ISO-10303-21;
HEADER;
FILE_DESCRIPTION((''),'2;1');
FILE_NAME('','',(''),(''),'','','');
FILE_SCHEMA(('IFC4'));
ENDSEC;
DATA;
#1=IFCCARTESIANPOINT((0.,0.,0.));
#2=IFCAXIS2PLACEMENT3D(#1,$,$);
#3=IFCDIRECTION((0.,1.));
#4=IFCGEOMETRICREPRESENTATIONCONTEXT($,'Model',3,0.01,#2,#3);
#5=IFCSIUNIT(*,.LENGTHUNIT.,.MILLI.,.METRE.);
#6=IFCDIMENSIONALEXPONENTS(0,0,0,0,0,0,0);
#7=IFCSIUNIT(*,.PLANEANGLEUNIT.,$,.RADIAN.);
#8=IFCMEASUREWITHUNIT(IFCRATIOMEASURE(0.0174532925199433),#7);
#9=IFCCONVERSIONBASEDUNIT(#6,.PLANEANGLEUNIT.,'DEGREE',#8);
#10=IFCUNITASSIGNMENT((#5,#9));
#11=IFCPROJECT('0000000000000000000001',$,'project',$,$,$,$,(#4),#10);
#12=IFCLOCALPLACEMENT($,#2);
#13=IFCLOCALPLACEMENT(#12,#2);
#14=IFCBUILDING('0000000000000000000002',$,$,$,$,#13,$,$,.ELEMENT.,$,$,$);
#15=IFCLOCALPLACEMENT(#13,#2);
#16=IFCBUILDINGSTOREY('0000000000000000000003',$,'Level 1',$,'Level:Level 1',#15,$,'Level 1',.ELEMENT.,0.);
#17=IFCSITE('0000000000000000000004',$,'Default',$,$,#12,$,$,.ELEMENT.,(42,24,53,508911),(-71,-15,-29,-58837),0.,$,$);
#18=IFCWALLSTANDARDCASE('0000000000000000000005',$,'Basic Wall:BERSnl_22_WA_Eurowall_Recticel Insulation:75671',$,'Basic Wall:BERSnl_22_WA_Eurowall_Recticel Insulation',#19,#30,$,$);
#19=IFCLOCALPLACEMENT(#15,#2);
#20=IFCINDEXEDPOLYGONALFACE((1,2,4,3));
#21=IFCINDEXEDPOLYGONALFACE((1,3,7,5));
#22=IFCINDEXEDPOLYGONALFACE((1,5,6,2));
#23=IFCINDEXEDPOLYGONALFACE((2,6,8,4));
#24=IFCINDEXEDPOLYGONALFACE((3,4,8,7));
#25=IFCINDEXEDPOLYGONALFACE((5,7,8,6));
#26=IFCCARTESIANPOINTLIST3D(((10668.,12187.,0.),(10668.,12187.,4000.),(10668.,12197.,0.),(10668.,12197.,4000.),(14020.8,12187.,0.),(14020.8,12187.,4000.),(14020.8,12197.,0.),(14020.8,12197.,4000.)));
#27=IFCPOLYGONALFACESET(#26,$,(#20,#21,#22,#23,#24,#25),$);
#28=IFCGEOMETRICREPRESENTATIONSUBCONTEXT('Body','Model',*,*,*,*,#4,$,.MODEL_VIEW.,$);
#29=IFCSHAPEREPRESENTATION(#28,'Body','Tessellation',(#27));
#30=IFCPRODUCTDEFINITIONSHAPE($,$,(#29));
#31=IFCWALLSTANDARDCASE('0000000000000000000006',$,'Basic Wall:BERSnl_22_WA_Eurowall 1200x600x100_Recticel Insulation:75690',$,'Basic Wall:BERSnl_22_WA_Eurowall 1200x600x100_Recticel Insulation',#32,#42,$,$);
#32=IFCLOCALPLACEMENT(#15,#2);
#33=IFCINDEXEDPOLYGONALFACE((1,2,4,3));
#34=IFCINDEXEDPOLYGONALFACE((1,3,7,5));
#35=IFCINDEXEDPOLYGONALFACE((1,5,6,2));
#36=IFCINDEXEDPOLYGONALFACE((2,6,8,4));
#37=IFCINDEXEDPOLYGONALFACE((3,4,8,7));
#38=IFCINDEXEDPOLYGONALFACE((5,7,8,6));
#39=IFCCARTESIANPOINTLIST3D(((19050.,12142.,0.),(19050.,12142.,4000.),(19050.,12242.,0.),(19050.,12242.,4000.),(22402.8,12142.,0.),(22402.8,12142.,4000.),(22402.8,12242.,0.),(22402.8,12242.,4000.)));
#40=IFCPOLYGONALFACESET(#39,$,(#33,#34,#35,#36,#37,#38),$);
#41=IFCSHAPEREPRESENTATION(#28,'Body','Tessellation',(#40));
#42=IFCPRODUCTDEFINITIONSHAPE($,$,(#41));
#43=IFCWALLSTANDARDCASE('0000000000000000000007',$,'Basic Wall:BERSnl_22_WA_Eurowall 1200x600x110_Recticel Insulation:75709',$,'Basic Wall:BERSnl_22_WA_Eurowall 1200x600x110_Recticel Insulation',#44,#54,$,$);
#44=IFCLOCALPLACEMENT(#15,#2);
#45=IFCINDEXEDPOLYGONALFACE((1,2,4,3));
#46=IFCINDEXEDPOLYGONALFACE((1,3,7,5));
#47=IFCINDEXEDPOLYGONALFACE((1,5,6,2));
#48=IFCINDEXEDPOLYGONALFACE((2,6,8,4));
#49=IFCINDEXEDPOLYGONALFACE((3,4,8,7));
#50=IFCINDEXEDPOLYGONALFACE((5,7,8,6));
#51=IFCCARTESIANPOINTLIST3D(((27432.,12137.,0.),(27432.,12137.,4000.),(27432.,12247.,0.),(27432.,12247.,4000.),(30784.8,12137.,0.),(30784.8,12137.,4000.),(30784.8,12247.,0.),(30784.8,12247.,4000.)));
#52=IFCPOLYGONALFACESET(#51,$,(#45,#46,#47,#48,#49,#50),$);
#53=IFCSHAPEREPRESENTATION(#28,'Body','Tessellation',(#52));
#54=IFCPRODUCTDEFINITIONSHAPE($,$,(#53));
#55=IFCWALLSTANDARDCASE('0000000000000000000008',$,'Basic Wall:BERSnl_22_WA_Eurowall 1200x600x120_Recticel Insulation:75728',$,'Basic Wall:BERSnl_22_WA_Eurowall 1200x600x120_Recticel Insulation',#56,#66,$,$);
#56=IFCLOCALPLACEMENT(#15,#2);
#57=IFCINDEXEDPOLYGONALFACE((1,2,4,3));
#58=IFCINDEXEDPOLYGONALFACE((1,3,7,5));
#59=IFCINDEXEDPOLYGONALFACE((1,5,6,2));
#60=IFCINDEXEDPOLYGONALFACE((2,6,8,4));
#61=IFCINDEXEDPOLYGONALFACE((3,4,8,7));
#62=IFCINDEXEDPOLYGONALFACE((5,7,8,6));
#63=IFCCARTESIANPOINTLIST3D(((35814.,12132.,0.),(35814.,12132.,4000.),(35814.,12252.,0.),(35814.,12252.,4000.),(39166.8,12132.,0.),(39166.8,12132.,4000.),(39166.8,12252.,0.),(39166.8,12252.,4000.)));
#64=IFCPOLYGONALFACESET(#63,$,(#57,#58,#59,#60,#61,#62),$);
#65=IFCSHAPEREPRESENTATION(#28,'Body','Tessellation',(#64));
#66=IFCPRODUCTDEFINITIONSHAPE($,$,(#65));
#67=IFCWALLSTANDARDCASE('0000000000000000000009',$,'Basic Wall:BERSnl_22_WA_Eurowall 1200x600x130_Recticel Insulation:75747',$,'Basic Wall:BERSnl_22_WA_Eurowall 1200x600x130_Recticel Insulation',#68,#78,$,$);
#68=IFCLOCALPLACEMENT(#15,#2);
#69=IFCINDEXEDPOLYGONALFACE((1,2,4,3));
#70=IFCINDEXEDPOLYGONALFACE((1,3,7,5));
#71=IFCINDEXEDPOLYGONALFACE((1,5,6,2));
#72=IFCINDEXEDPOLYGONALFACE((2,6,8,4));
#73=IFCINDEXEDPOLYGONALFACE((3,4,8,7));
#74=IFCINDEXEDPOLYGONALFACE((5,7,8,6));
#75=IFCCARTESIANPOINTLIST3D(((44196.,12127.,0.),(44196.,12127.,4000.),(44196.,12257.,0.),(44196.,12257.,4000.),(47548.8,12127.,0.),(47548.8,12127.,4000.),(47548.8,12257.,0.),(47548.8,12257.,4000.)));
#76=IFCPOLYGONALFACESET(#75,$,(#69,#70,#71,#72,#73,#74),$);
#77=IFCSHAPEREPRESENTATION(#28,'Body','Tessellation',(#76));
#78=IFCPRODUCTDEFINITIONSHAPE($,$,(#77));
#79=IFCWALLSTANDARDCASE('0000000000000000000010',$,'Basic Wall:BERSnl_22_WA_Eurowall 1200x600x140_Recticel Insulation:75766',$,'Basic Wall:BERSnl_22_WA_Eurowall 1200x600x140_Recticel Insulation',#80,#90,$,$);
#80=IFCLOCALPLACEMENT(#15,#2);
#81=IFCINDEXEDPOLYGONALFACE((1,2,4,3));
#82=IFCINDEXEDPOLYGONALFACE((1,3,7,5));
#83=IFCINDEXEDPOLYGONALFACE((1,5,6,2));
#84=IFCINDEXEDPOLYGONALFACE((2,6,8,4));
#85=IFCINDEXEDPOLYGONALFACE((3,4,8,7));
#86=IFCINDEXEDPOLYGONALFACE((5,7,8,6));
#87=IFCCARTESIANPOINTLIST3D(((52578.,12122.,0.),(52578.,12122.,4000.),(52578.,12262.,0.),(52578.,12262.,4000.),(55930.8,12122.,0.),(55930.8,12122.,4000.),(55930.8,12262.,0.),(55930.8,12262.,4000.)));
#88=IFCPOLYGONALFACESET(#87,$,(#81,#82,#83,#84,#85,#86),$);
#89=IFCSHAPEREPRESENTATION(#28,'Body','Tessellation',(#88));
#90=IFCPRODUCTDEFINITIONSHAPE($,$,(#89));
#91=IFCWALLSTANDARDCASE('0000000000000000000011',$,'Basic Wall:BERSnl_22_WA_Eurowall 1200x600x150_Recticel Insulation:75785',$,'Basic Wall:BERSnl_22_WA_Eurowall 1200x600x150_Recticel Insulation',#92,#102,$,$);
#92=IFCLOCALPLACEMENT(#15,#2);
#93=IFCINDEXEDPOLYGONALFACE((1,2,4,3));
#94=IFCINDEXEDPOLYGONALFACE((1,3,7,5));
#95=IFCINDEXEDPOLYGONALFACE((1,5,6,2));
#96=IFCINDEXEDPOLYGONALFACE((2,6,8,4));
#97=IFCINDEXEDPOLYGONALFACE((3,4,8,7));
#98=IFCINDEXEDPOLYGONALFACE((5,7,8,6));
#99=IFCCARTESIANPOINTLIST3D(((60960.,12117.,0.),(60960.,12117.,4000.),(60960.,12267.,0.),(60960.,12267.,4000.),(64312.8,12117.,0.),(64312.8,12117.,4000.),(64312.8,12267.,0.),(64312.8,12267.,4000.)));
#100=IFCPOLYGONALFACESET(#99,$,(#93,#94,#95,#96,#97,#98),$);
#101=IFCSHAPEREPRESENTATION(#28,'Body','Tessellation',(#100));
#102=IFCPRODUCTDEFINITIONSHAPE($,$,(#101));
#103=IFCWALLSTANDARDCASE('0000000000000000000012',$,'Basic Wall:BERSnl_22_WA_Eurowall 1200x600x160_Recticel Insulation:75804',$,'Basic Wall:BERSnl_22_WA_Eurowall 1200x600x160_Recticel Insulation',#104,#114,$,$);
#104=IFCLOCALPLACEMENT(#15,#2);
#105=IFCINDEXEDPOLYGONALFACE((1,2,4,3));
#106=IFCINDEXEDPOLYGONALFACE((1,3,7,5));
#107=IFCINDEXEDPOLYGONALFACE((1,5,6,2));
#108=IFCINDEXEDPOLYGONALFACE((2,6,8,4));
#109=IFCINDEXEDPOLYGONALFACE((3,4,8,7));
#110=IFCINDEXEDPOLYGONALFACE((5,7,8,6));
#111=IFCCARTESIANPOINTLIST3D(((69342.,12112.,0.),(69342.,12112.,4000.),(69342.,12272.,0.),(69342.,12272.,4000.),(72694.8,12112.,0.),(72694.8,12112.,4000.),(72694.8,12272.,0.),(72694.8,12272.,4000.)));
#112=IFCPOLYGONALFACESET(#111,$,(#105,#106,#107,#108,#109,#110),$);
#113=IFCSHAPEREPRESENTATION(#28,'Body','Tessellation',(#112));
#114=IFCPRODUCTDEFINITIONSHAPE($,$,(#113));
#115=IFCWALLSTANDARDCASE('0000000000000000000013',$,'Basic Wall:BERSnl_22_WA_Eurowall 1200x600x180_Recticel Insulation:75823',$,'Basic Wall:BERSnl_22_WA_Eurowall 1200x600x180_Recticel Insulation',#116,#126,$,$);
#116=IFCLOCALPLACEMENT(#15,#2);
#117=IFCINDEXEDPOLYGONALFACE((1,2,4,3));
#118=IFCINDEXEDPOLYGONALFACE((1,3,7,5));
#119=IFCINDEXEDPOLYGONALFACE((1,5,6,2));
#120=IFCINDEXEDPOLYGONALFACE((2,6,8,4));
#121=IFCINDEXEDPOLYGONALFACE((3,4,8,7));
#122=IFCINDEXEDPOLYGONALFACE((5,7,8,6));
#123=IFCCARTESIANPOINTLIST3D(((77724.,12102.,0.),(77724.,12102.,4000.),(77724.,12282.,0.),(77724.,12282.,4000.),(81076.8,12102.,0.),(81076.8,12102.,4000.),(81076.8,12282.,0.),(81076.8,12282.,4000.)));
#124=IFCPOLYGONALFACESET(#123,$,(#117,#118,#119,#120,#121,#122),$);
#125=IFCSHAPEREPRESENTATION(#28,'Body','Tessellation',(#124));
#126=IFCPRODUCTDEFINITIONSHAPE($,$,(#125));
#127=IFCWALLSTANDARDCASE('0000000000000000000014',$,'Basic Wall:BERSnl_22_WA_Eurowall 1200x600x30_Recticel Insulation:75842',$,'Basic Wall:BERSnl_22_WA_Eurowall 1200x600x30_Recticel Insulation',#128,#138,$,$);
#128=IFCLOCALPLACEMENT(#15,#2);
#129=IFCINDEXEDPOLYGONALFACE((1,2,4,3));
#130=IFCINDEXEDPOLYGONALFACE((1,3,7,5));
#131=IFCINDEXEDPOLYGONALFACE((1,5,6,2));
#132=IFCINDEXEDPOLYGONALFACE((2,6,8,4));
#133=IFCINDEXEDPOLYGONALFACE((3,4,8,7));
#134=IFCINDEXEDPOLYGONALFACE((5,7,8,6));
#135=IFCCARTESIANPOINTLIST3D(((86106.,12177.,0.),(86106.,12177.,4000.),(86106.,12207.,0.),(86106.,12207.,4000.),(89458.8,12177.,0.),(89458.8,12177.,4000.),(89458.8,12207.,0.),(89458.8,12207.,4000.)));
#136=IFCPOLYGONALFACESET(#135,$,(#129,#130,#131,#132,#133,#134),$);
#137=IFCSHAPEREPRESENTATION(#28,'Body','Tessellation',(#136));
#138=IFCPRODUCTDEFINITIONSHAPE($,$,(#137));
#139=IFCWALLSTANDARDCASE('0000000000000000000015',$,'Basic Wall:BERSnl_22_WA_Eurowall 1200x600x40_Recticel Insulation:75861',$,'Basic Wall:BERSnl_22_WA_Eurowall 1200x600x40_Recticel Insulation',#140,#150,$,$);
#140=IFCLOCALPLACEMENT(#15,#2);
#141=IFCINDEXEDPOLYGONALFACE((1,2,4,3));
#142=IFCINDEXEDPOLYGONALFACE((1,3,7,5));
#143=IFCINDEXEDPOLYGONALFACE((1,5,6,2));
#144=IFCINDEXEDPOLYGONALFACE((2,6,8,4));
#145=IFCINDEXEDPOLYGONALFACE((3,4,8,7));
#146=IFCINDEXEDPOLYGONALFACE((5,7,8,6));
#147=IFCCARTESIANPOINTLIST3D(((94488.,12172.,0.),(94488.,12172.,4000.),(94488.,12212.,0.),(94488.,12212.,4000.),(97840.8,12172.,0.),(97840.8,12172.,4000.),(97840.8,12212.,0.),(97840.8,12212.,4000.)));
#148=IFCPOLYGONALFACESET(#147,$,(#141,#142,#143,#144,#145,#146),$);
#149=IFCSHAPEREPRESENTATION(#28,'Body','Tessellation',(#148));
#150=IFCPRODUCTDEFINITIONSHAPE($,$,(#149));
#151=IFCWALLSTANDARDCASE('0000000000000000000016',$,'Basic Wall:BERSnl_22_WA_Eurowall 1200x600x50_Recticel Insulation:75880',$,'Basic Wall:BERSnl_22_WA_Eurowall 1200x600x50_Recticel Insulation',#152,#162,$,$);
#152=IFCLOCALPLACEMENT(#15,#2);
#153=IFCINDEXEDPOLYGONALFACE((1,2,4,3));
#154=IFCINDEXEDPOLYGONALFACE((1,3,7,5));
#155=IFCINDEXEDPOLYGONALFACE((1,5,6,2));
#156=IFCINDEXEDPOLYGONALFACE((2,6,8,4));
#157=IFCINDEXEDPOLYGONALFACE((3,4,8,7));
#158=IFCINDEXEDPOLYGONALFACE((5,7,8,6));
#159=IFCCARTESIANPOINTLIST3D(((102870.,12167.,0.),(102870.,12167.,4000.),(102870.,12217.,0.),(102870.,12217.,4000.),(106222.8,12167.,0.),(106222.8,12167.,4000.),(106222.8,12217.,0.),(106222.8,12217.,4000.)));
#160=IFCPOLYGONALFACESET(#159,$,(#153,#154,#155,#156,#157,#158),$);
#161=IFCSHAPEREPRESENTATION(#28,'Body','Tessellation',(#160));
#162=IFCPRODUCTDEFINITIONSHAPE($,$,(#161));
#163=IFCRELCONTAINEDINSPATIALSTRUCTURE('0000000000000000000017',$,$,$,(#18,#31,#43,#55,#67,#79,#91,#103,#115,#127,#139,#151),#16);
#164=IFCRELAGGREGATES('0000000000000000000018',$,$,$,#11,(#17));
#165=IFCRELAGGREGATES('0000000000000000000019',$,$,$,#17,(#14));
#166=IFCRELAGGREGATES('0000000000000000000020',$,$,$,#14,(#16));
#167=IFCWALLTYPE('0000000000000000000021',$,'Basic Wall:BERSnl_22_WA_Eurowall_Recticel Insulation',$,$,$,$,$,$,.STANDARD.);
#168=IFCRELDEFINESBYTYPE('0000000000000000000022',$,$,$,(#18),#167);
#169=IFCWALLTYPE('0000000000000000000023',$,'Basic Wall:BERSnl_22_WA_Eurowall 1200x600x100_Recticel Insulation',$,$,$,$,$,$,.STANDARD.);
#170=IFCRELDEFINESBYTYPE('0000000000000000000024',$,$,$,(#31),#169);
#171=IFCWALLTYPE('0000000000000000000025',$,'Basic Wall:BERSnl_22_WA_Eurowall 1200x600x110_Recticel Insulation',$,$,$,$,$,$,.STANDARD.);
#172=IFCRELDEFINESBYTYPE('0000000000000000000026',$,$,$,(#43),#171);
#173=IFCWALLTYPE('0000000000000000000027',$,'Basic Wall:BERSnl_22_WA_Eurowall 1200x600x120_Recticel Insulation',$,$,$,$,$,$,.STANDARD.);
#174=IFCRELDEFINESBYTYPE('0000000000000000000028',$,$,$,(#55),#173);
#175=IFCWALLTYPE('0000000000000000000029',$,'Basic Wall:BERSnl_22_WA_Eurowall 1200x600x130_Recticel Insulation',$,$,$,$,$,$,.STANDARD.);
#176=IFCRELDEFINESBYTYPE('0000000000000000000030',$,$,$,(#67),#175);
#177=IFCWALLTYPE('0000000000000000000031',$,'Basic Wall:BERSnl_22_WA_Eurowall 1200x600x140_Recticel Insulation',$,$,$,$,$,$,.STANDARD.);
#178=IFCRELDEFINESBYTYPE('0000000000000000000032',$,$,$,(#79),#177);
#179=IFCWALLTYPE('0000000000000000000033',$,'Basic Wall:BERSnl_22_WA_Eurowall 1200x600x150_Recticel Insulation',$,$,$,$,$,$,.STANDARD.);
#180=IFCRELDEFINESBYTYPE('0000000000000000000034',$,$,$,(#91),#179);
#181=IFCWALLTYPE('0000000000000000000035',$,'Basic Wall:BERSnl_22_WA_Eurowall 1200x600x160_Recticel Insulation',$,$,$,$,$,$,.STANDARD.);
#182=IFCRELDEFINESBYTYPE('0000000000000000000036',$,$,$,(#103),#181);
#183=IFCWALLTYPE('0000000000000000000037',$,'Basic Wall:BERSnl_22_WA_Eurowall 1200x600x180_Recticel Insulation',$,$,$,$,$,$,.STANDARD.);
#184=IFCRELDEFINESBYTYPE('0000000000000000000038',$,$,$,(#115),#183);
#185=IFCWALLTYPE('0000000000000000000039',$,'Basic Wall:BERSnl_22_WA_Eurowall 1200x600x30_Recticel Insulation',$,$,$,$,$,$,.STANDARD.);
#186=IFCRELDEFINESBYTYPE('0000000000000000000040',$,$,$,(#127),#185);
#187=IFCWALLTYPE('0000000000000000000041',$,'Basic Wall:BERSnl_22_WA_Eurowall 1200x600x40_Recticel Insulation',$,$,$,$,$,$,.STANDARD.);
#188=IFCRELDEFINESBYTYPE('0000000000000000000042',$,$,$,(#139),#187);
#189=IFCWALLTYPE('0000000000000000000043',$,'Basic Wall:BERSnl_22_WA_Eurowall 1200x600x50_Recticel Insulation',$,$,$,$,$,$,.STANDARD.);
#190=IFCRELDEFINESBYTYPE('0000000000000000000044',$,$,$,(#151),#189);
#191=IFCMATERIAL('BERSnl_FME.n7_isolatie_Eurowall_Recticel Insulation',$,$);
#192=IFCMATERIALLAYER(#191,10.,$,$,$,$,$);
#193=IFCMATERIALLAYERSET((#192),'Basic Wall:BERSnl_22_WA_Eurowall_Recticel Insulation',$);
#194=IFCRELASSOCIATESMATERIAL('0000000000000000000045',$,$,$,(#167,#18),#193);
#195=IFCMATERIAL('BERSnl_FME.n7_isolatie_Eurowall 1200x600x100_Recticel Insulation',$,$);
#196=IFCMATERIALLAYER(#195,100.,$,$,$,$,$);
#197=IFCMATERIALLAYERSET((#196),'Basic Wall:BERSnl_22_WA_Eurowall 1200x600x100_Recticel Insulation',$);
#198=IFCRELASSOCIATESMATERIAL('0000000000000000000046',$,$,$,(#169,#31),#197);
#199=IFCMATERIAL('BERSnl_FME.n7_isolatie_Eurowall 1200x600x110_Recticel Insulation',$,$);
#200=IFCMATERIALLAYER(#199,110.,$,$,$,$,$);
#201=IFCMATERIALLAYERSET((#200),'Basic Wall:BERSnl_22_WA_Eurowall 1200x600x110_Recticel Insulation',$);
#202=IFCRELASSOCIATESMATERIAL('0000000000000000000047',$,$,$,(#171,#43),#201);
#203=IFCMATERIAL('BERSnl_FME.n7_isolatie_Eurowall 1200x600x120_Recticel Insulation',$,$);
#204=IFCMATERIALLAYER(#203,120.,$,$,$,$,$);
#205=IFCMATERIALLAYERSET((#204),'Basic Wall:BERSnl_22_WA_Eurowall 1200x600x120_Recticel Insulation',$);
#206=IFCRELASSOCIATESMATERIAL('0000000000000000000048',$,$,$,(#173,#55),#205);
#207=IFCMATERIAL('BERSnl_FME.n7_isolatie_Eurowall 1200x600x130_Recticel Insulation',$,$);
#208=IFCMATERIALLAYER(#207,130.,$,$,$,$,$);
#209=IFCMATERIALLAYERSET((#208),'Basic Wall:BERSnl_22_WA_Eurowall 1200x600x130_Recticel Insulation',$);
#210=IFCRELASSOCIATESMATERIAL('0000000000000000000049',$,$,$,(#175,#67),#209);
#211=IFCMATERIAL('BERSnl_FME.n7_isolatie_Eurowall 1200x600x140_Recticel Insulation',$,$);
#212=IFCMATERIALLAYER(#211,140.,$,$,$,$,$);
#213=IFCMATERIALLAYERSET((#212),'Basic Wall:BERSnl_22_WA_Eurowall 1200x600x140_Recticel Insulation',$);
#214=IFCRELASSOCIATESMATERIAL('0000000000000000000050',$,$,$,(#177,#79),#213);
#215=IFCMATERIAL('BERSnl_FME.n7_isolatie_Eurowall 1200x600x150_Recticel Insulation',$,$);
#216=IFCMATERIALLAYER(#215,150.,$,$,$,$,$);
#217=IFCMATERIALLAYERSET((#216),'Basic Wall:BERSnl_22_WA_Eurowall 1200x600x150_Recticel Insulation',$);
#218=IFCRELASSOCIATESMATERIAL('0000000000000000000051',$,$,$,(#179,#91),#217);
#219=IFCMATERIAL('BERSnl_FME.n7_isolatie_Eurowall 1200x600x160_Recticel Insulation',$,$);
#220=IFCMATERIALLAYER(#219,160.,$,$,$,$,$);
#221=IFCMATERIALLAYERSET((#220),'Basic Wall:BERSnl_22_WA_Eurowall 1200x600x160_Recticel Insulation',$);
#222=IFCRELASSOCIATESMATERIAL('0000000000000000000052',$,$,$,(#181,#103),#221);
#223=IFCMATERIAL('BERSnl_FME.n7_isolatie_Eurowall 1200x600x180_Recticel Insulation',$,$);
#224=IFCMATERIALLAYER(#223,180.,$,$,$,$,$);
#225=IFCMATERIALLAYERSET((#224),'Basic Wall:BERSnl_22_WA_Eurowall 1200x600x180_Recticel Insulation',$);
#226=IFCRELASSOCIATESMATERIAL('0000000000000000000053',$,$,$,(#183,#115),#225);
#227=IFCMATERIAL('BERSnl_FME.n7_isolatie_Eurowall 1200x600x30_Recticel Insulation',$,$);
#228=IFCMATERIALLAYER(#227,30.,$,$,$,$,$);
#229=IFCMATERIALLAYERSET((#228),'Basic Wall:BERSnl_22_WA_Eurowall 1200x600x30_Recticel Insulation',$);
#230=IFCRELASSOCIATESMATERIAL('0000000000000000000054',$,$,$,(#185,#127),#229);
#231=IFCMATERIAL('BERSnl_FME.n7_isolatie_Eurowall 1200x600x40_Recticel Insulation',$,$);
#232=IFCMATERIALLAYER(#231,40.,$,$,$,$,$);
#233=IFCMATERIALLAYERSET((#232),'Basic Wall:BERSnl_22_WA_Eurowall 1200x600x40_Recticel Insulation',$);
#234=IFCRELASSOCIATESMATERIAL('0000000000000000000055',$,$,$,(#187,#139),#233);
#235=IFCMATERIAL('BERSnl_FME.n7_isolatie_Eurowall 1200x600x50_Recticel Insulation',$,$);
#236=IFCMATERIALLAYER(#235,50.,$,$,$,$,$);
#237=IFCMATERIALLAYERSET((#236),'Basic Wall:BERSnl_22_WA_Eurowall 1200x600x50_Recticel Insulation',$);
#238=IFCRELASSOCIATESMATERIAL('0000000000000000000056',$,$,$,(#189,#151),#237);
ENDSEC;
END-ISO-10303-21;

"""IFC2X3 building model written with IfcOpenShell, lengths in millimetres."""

from ifc_helpers import new_model, entity, si_unit, converted_unit, direction, frame, frame_2d, origin, place, context, subcontext, project, spatial, rectangle, extrude, material, layer, layer_set, layer_usage, type_object, element, save


model = new_model("IFC2X3")

# Units and contexts
model_context = context("Model", 3, precision=0.01, world=origin(), true_north=direction((0.0, 1.0)))
body_context = subcontext(model_context, "Body", "Model", "MODEL_VIEW")
ifc_project = project(units=[si_unit("LENGTHUNIT", "METRE", prefix="MILLI"), converted_unit("PLANEANGLEUNIT", "DEGREE", entity("IfcRatioMeasure", 0.0174532925199433), si_unit("PLANEANGLEUNIT", "RADIAN"), dimensions=[0, 0, 0, 0, 0, 0, 0])], contexts=[model_context])

# Site, building, storey
site_placement = place(None, origin())
site = spatial("IfcSite", under=ifc_project, at=site_placement, Name="Default", CompositionType="ELEMENT", RefLatitude=(42, 24, 53, 508911), RefLongitude=(-71, -15, -29, -58837), RefElevation=0.0)
building_placement = place(site_placement, origin())
building = spatial("IfcBuilding", under=site, at=building_placement, CompositionType="ELEMENT")
storey_placement = place(building_placement, origin())
storey = spatial("IfcBuildingStorey", under=building, at=storey_placement, Name="Level 1", ObjectType="Level:Level 1", LongName="Level 1", CompositionType="ELEMENT", Elevation=0.0)

# Walls
ifc_material_1 = material(Name="BERSnl_FME.n7_isolatie_Eurowall_Recticel Insulation")
ifc_layer_1 = layer(ifc_material_1, 10.0)
ifc_layer_set_1 = layer_set([ifc_layer_1], Name="Basic Wall:BERSnl_22_WA_Eurowall_Recticel Insulation")
ifc_layer_usage_1 = layer_usage(ifc_layer_set_1, "AXIS2", "NEGATIVE", 5.0)
wall_type_1 = type_object("IfcWallType", Name="Basic Wall:BERSnl_22_WA_Eurowall_Recticel Insulation", PredefinedType="STANDARD", material=ifc_layer_set_1)
wall_1_placement = place(storey_placement, frame((10668.0, 12192.0, 0.0)))
element("IfcWallStandardCase", 1, at=wall_1_placement, inside=storey, type_object=wall_type_1, material=ifc_layer_usage_1, Name="Basic Wall:BERSnl_22_WA_Eurowall_Recticel Insulation:75671", ObjectType="Basic Wall:BERSnl_22_WA_Eurowall_Recticel Insulation", context=body_context, shape_type="SweptSolid", body=[
    extrude(rectangle(XDim=3352.8, YDim=10.0, at=frame_2d((1676.4, 0.0), x_axis=(-1.0, 0.0))), origin(), (0.0, 0.0, 1.0), 4000.0),
])
ifc_material_2 = material(Name="BERSnl_FME.n7_isolatie_Eurowall 1200x600x100_Recticel Insulation")
ifc_layer_2 = layer(ifc_material_2, 100.0)
ifc_layer_set_2 = layer_set([ifc_layer_2], Name="Basic Wall:BERSnl_22_WA_Eurowall 1200x600x100_Recticel Insulation")
ifc_layer_usage_2 = layer_usage(ifc_layer_set_2, "AXIS2", "NEGATIVE", 50.0)
wall_type_2 = type_object("IfcWallType", Name="Basic Wall:BERSnl_22_WA_Eurowall 1200x600x100_Recticel Insulation", PredefinedType="STANDARD", material=ifc_layer_set_2)
wall_2_placement = place(storey_placement, frame((19050.0, 12192.0, 0.0)))
element("IfcWallStandardCase", 2, at=wall_2_placement, inside=storey, type_object=wall_type_2, material=ifc_layer_usage_2, Name="Basic Wall:BERSnl_22_WA_Eurowall 1200x600x100_Recticel Insulation:75690", ObjectType="Basic Wall:BERSnl_22_WA_Eurowall 1200x600x100_Recticel Insulation", context=body_context, shape_type="SweptSolid", body=[
    extrude(rectangle(XDim=3352.8, YDim=100.0, at=frame_2d((1676.4, 0.0), x_axis=(-1.0, 0.0))), origin(), (0.0, 0.0, 1.0), 4000.0),
])
ifc_material_3 = material(Name="BERSnl_FME.n7_isolatie_Eurowall 1200x600x110_Recticel Insulation")
ifc_layer_3 = layer(ifc_material_3, 110.0)
ifc_layer_set_3 = layer_set([ifc_layer_3], Name="Basic Wall:BERSnl_22_WA_Eurowall 1200x600x110_Recticel Insulation")
ifc_layer_usage_3 = layer_usage(ifc_layer_set_3, "AXIS2", "NEGATIVE", 55.0)
wall_type_3 = type_object("IfcWallType", Name="Basic Wall:BERSnl_22_WA_Eurowall 1200x600x110_Recticel Insulation", PredefinedType="STANDARD", material=ifc_layer_set_3)
wall_3_placement = place(storey_placement, frame((27432.0, 12192.0, 0.0)))
element("IfcWallStandardCase", 3, at=wall_3_placement, inside=storey, type_object=wall_type_3, material=ifc_layer_usage_3, Name="Basic Wall:BERSnl_22_WA_Eurowall 1200x600x110_Recticel Insulation:75709", ObjectType="Basic Wall:BERSnl_22_WA_Eurowall 1200x600x110_Recticel Insulation", context=body_context, shape_type="SweptSolid", body=[
    extrude(rectangle(XDim=3352.8, YDim=110.0, at=frame_2d((1676.4, 0.0), x_axis=(-1.0, 0.0))), origin(), (0.0, 0.0, 1.0), 4000.0),
])
ifc_material_4 = material(Name="BERSnl_FME.n7_isolatie_Eurowall 1200x600x120_Recticel Insulation")
ifc_layer_4 = layer(ifc_material_4, 120.0)
ifc_layer_set_4 = layer_set([ifc_layer_4], Name="Basic Wall:BERSnl_22_WA_Eurowall 1200x600x120_Recticel Insulation")
ifc_layer_usage_4 = layer_usage(ifc_layer_set_4, "AXIS2", "NEGATIVE", 60.0)
wall_type_4 = type_object("IfcWallType", Name="Basic Wall:BERSnl_22_WA_Eurowall 1200x600x120_Recticel Insulation", PredefinedType="STANDARD", material=ifc_layer_set_4)
wall_4_placement = place(storey_placement, frame((35814.0, 12192.0, 0.0)))
element("IfcWallStandardCase", 4, at=wall_4_placement, inside=storey, type_object=wall_type_4, material=ifc_layer_usage_4, Name="Basic Wall:BERSnl_22_WA_Eurowall 1200x600x120_Recticel Insulation:75728", ObjectType="Basic Wall:BERSnl_22_WA_Eurowall 1200x600x120_Recticel Insulation", context=body_context, shape_type="SweptSolid", body=[
    extrude(rectangle(XDim=3352.8, YDim=120.0, at=frame_2d((1676.4, 0.0), x_axis=(-1.0, 0.0))), origin(), (0.0, 0.0, 1.0), 4000.0),
])
ifc_material_5 = material(Name="BERSnl_FME.n7_isolatie_Eurowall 1200x600x130_Recticel Insulation")
ifc_layer_5 = layer(ifc_material_5, 130.0)
ifc_layer_set_5 = layer_set([ifc_layer_5], Name="Basic Wall:BERSnl_22_WA_Eurowall 1200x600x130_Recticel Insulation")
ifc_layer_usage_5 = layer_usage(ifc_layer_set_5, "AXIS2", "NEGATIVE", 65.0)
wall_type_5 = type_object("IfcWallType", Name="Basic Wall:BERSnl_22_WA_Eurowall 1200x600x130_Recticel Insulation", PredefinedType="STANDARD", material=ifc_layer_set_5)
wall_5_placement = place(storey_placement, frame((44196.0, 12192.0, 0.0)))
element("IfcWallStandardCase", 5, at=wall_5_placement, inside=storey, type_object=wall_type_5, material=ifc_layer_usage_5, Name="Basic Wall:BERSnl_22_WA_Eurowall 1200x600x130_Recticel Insulation:75747", ObjectType="Basic Wall:BERSnl_22_WA_Eurowall 1200x600x130_Recticel Insulation", context=body_context, shape_type="SweptSolid", body=[
    extrude(rectangle(XDim=3352.8, YDim=130.0, at=frame_2d((1676.4, 0.0), x_axis=(-1.0, 0.0))), origin(), (0.0, 0.0, 1.0), 4000.0),
])
ifc_material_6 = material(Name="BERSnl_FME.n7_isolatie_Eurowall 1200x600x140_Recticel Insulation")
ifc_layer_6 = layer(ifc_material_6, 140.0)
ifc_layer_set_6 = layer_set([ifc_layer_6], Name="Basic Wall:BERSnl_22_WA_Eurowall 1200x600x140_Recticel Insulation")
ifc_layer_usage_6 = layer_usage(ifc_layer_set_6, "AXIS2", "NEGATIVE", 70.0)
wall_type_6 = type_object("IfcWallType", Name="Basic Wall:BERSnl_22_WA_Eurowall 1200x600x140_Recticel Insulation", PredefinedType="STANDARD", material=ifc_layer_set_6)
wall_6_placement = place(storey_placement, frame((52578.0, 12192.0, 0.0)))
element("IfcWallStandardCase", 6, at=wall_6_placement, inside=storey, type_object=wall_type_6, material=ifc_layer_usage_6, Name="Basic Wall:BERSnl_22_WA_Eurowall 1200x600x140_Recticel Insulation:75766", ObjectType="Basic Wall:BERSnl_22_WA_Eurowall 1200x600x140_Recticel Insulation", context=body_context, shape_type="SweptSolid", body=[
    extrude(rectangle(XDim=3352.8, YDim=140.0, at=frame_2d((1676.4, 0.0), x_axis=(-1.0, 0.0))), origin(), (0.0, 0.0, 1.0), 4000.0),
])
ifc_material_7 = material(Name="BERSnl_FME.n7_isolatie_Eurowall 1200x600x150_Recticel Insulation")
ifc_layer_7 = layer(ifc_material_7, 150.0)
ifc_layer_set_7 = layer_set([ifc_layer_7], Name="Basic Wall:BERSnl_22_WA_Eurowall 1200x600x150_Recticel Insulation")
ifc_layer_usage_7 = layer_usage(ifc_layer_set_7, "AXIS2", "NEGATIVE", 75.0)
wall_type_7 = type_object("IfcWallType", Name="Basic Wall:BERSnl_22_WA_Eurowall 1200x600x150_Recticel Insulation", PredefinedType="STANDARD", material=ifc_layer_set_7)
wall_7_placement = place(storey_placement, frame((60960.0, 12192.0, 0.0)))
element("IfcWallStandardCase", 7, at=wall_7_placement, inside=storey, type_object=wall_type_7, material=ifc_layer_usage_7, Name="Basic Wall:BERSnl_22_WA_Eurowall 1200x600x150_Recticel Insulation:75785", ObjectType="Basic Wall:BERSnl_22_WA_Eurowall 1200x600x150_Recticel Insulation", context=body_context, shape_type="SweptSolid", body=[
    extrude(rectangle(XDim=3352.8, YDim=150.0, at=frame_2d((1676.4, 0.0), x_axis=(-1.0, 0.0))), origin(), (0.0, 0.0, 1.0), 4000.0),
])
ifc_material_8 = material(Name="BERSnl_FME.n7_isolatie_Eurowall 1200x600x160_Recticel Insulation")
ifc_layer_8 = layer(ifc_material_8, 160.0)
ifc_layer_set_8 = layer_set([ifc_layer_8], Name="Basic Wall:BERSnl_22_WA_Eurowall 1200x600x160_Recticel Insulation")
ifc_layer_usage_8 = layer_usage(ifc_layer_set_8, "AXIS2", "NEGATIVE", 80.0)
wall_type_8 = type_object("IfcWallType", Name="Basic Wall:BERSnl_22_WA_Eurowall 1200x600x160_Recticel Insulation", PredefinedType="STANDARD", material=ifc_layer_set_8)
wall_8_placement = place(storey_placement, frame((69342.0, 12192.0, 0.0)))
element("IfcWallStandardCase", 8, at=wall_8_placement, inside=storey, type_object=wall_type_8, material=ifc_layer_usage_8, Name="Basic Wall:BERSnl_22_WA_Eurowall 1200x600x160_Recticel Insulation:75804", ObjectType="Basic Wall:BERSnl_22_WA_Eurowall 1200x600x160_Recticel Insulation", context=body_context, shape_type="SweptSolid", body=[
    extrude(rectangle(XDim=3352.8, YDim=160.0, at=frame_2d((1676.4, 0.0), x_axis=(-1.0, 0.0))), origin(), (0.0, 0.0, 1.0), 4000.0),
])
ifc_material_9 = material(Name="BERSnl_FME.n7_isolatie_Eurowall 1200x600x180_Recticel Insulation")
ifc_layer_9 = layer(ifc_material_9, 180.0)
ifc_layer_set_9 = layer_set([ifc_layer_9], Name="Basic Wall:BERSnl_22_WA_Eurowall 1200x600x180_Recticel Insulation")
ifc_layer_usage_9 = layer_usage(ifc_layer_set_9, "AXIS2", "NEGATIVE", 90.0)
wall_type_9 = type_object("IfcWallType", Name="Basic Wall:BERSnl_22_WA_Eurowall 1200x600x180_Recticel Insulation", PredefinedType="STANDARD", material=ifc_layer_set_9)
wall_9_placement = place(storey_placement, frame((77724.0, 12192.0, 0.0)))
element("IfcWallStandardCase", 9, at=wall_9_placement, inside=storey, type_object=wall_type_9, material=ifc_layer_usage_9, Name="Basic Wall:BERSnl_22_WA_Eurowall 1200x600x180_Recticel Insulation:75823", ObjectType="Basic Wall:BERSnl_22_WA_Eurowall 1200x600x180_Recticel Insulation", context=body_context, shape_type="SweptSolid", body=[
    extrude(rectangle(XDim=3352.8, YDim=180.0, at=frame_2d((1676.4, 0.0), x_axis=(-1.0, 0.0))), origin(), (0.0, 0.0, 1.0), 4000.0),
])
ifc_material_10 = material(Name="BERSnl_FME.n7_isolatie_Eurowall 1200x600x30_Recticel Insulation")
ifc_layer_10 = layer(ifc_material_10, 30.0)
ifc_layer_set_10 = layer_set([ifc_layer_10], Name="Basic Wall:BERSnl_22_WA_Eurowall 1200x600x30_Recticel Insulation")
ifc_layer_usage_10 = layer_usage(ifc_layer_set_10, "AXIS2", "NEGATIVE", 15.0)
wall_type_10 = type_object("IfcWallType", Name="Basic Wall:BERSnl_22_WA_Eurowall 1200x600x30_Recticel Insulation", PredefinedType="STANDARD", material=ifc_layer_set_10)
wall_10_placement = place(storey_placement, frame((86106.0, 12192.0, 0.0)))
element("IfcWallStandardCase", 10, at=wall_10_placement, inside=storey, type_object=wall_type_10, material=ifc_layer_usage_10, Name="Basic Wall:BERSnl_22_WA_Eurowall 1200x600x30_Recticel Insulation:75842", ObjectType="Basic Wall:BERSnl_22_WA_Eurowall 1200x600x30_Recticel Insulation", context=body_context, shape_type="SweptSolid", body=[
    extrude(rectangle(XDim=3352.8, YDim=30.0, at=frame_2d((1676.4, 0.0), x_axis=(-1.0, 0.0))), origin(), (0.0, 0.0, 1.0), 4000.0),
])
ifc_material_11 = material(Name="BERSnl_FME.n7_isolatie_Eurowall 1200x600x40_Recticel Insulation")
ifc_layer_11 = layer(ifc_material_11, 40.0)
ifc_layer_set_11 = layer_set([ifc_layer_11], Name="Basic Wall:BERSnl_22_WA_Eurowall 1200x600x40_Recticel Insulation")
ifc_layer_usage_11 = layer_usage(ifc_layer_set_11, "AXIS2", "NEGATIVE", 20.0)
wall_type_11 = type_object("IfcWallType", Name="Basic Wall:BERSnl_22_WA_Eurowall 1200x600x40_Recticel Insulation", PredefinedType="STANDARD", material=ifc_layer_set_11)
wall_11_placement = place(storey_placement, frame((94488.0, 12192.0, 0.0)))
element("IfcWallStandardCase", 11, at=wall_11_placement, inside=storey, type_object=wall_type_11, material=ifc_layer_usage_11, Name="Basic Wall:BERSnl_22_WA_Eurowall 1200x600x40_Recticel Insulation:75861", ObjectType="Basic Wall:BERSnl_22_WA_Eurowall 1200x600x40_Recticel Insulation", context=body_context, shape_type="SweptSolid", body=[
    extrude(rectangle(XDim=3352.8, YDim=40.0, at=frame_2d((1676.4, 0.0), x_axis=(-1.0, 0.0))), origin(), (0.0, 0.0, 1.0), 4000.0),
])
ifc_material_12 = material(Name="BERSnl_FME.n7_isolatie_Eurowall 1200x600x50_Recticel Insulation")
ifc_layer_12 = layer(ifc_material_12, 50.0)
ifc_layer_set_12 = layer_set([ifc_layer_12], Name="Basic Wall:BERSnl_22_WA_Eurowall 1200x600x50_Recticel Insulation")
ifc_layer_usage_12 = layer_usage(ifc_layer_set_12, "AXIS2", "NEGATIVE", 25.0)
wall_type_12 = type_object("IfcWallType", Name="Basic Wall:BERSnl_22_WA_Eurowall 1200x600x50_Recticel Insulation", PredefinedType="STANDARD", material=ifc_layer_set_12)
wall_12_placement = place(storey_placement, frame((102870.0, 12192.0, 0.0)))
element("IfcWallStandardCase", 12, at=wall_12_placement, inside=storey, type_object=wall_type_12, material=ifc_layer_usage_12, Name="Basic Wall:BERSnl_22_WA_Eurowall 1200x600x50_Recticel Insulation:75880", ObjectType="Basic Wall:BERSnl_22_WA_Eurowall 1200x600x50_Recticel Insulation", context=body_context, shape_type="SweptSolid", body=[
    extrude(rectangle(XDim=3352.8, YDim=50.0, at=frame_2d((1676.4, 0.0), x_axis=(-1.0, 0.0))), origin(), (0.0, 0.0, 1.0), 4000.0),
])

save(model, "model.ifc")
